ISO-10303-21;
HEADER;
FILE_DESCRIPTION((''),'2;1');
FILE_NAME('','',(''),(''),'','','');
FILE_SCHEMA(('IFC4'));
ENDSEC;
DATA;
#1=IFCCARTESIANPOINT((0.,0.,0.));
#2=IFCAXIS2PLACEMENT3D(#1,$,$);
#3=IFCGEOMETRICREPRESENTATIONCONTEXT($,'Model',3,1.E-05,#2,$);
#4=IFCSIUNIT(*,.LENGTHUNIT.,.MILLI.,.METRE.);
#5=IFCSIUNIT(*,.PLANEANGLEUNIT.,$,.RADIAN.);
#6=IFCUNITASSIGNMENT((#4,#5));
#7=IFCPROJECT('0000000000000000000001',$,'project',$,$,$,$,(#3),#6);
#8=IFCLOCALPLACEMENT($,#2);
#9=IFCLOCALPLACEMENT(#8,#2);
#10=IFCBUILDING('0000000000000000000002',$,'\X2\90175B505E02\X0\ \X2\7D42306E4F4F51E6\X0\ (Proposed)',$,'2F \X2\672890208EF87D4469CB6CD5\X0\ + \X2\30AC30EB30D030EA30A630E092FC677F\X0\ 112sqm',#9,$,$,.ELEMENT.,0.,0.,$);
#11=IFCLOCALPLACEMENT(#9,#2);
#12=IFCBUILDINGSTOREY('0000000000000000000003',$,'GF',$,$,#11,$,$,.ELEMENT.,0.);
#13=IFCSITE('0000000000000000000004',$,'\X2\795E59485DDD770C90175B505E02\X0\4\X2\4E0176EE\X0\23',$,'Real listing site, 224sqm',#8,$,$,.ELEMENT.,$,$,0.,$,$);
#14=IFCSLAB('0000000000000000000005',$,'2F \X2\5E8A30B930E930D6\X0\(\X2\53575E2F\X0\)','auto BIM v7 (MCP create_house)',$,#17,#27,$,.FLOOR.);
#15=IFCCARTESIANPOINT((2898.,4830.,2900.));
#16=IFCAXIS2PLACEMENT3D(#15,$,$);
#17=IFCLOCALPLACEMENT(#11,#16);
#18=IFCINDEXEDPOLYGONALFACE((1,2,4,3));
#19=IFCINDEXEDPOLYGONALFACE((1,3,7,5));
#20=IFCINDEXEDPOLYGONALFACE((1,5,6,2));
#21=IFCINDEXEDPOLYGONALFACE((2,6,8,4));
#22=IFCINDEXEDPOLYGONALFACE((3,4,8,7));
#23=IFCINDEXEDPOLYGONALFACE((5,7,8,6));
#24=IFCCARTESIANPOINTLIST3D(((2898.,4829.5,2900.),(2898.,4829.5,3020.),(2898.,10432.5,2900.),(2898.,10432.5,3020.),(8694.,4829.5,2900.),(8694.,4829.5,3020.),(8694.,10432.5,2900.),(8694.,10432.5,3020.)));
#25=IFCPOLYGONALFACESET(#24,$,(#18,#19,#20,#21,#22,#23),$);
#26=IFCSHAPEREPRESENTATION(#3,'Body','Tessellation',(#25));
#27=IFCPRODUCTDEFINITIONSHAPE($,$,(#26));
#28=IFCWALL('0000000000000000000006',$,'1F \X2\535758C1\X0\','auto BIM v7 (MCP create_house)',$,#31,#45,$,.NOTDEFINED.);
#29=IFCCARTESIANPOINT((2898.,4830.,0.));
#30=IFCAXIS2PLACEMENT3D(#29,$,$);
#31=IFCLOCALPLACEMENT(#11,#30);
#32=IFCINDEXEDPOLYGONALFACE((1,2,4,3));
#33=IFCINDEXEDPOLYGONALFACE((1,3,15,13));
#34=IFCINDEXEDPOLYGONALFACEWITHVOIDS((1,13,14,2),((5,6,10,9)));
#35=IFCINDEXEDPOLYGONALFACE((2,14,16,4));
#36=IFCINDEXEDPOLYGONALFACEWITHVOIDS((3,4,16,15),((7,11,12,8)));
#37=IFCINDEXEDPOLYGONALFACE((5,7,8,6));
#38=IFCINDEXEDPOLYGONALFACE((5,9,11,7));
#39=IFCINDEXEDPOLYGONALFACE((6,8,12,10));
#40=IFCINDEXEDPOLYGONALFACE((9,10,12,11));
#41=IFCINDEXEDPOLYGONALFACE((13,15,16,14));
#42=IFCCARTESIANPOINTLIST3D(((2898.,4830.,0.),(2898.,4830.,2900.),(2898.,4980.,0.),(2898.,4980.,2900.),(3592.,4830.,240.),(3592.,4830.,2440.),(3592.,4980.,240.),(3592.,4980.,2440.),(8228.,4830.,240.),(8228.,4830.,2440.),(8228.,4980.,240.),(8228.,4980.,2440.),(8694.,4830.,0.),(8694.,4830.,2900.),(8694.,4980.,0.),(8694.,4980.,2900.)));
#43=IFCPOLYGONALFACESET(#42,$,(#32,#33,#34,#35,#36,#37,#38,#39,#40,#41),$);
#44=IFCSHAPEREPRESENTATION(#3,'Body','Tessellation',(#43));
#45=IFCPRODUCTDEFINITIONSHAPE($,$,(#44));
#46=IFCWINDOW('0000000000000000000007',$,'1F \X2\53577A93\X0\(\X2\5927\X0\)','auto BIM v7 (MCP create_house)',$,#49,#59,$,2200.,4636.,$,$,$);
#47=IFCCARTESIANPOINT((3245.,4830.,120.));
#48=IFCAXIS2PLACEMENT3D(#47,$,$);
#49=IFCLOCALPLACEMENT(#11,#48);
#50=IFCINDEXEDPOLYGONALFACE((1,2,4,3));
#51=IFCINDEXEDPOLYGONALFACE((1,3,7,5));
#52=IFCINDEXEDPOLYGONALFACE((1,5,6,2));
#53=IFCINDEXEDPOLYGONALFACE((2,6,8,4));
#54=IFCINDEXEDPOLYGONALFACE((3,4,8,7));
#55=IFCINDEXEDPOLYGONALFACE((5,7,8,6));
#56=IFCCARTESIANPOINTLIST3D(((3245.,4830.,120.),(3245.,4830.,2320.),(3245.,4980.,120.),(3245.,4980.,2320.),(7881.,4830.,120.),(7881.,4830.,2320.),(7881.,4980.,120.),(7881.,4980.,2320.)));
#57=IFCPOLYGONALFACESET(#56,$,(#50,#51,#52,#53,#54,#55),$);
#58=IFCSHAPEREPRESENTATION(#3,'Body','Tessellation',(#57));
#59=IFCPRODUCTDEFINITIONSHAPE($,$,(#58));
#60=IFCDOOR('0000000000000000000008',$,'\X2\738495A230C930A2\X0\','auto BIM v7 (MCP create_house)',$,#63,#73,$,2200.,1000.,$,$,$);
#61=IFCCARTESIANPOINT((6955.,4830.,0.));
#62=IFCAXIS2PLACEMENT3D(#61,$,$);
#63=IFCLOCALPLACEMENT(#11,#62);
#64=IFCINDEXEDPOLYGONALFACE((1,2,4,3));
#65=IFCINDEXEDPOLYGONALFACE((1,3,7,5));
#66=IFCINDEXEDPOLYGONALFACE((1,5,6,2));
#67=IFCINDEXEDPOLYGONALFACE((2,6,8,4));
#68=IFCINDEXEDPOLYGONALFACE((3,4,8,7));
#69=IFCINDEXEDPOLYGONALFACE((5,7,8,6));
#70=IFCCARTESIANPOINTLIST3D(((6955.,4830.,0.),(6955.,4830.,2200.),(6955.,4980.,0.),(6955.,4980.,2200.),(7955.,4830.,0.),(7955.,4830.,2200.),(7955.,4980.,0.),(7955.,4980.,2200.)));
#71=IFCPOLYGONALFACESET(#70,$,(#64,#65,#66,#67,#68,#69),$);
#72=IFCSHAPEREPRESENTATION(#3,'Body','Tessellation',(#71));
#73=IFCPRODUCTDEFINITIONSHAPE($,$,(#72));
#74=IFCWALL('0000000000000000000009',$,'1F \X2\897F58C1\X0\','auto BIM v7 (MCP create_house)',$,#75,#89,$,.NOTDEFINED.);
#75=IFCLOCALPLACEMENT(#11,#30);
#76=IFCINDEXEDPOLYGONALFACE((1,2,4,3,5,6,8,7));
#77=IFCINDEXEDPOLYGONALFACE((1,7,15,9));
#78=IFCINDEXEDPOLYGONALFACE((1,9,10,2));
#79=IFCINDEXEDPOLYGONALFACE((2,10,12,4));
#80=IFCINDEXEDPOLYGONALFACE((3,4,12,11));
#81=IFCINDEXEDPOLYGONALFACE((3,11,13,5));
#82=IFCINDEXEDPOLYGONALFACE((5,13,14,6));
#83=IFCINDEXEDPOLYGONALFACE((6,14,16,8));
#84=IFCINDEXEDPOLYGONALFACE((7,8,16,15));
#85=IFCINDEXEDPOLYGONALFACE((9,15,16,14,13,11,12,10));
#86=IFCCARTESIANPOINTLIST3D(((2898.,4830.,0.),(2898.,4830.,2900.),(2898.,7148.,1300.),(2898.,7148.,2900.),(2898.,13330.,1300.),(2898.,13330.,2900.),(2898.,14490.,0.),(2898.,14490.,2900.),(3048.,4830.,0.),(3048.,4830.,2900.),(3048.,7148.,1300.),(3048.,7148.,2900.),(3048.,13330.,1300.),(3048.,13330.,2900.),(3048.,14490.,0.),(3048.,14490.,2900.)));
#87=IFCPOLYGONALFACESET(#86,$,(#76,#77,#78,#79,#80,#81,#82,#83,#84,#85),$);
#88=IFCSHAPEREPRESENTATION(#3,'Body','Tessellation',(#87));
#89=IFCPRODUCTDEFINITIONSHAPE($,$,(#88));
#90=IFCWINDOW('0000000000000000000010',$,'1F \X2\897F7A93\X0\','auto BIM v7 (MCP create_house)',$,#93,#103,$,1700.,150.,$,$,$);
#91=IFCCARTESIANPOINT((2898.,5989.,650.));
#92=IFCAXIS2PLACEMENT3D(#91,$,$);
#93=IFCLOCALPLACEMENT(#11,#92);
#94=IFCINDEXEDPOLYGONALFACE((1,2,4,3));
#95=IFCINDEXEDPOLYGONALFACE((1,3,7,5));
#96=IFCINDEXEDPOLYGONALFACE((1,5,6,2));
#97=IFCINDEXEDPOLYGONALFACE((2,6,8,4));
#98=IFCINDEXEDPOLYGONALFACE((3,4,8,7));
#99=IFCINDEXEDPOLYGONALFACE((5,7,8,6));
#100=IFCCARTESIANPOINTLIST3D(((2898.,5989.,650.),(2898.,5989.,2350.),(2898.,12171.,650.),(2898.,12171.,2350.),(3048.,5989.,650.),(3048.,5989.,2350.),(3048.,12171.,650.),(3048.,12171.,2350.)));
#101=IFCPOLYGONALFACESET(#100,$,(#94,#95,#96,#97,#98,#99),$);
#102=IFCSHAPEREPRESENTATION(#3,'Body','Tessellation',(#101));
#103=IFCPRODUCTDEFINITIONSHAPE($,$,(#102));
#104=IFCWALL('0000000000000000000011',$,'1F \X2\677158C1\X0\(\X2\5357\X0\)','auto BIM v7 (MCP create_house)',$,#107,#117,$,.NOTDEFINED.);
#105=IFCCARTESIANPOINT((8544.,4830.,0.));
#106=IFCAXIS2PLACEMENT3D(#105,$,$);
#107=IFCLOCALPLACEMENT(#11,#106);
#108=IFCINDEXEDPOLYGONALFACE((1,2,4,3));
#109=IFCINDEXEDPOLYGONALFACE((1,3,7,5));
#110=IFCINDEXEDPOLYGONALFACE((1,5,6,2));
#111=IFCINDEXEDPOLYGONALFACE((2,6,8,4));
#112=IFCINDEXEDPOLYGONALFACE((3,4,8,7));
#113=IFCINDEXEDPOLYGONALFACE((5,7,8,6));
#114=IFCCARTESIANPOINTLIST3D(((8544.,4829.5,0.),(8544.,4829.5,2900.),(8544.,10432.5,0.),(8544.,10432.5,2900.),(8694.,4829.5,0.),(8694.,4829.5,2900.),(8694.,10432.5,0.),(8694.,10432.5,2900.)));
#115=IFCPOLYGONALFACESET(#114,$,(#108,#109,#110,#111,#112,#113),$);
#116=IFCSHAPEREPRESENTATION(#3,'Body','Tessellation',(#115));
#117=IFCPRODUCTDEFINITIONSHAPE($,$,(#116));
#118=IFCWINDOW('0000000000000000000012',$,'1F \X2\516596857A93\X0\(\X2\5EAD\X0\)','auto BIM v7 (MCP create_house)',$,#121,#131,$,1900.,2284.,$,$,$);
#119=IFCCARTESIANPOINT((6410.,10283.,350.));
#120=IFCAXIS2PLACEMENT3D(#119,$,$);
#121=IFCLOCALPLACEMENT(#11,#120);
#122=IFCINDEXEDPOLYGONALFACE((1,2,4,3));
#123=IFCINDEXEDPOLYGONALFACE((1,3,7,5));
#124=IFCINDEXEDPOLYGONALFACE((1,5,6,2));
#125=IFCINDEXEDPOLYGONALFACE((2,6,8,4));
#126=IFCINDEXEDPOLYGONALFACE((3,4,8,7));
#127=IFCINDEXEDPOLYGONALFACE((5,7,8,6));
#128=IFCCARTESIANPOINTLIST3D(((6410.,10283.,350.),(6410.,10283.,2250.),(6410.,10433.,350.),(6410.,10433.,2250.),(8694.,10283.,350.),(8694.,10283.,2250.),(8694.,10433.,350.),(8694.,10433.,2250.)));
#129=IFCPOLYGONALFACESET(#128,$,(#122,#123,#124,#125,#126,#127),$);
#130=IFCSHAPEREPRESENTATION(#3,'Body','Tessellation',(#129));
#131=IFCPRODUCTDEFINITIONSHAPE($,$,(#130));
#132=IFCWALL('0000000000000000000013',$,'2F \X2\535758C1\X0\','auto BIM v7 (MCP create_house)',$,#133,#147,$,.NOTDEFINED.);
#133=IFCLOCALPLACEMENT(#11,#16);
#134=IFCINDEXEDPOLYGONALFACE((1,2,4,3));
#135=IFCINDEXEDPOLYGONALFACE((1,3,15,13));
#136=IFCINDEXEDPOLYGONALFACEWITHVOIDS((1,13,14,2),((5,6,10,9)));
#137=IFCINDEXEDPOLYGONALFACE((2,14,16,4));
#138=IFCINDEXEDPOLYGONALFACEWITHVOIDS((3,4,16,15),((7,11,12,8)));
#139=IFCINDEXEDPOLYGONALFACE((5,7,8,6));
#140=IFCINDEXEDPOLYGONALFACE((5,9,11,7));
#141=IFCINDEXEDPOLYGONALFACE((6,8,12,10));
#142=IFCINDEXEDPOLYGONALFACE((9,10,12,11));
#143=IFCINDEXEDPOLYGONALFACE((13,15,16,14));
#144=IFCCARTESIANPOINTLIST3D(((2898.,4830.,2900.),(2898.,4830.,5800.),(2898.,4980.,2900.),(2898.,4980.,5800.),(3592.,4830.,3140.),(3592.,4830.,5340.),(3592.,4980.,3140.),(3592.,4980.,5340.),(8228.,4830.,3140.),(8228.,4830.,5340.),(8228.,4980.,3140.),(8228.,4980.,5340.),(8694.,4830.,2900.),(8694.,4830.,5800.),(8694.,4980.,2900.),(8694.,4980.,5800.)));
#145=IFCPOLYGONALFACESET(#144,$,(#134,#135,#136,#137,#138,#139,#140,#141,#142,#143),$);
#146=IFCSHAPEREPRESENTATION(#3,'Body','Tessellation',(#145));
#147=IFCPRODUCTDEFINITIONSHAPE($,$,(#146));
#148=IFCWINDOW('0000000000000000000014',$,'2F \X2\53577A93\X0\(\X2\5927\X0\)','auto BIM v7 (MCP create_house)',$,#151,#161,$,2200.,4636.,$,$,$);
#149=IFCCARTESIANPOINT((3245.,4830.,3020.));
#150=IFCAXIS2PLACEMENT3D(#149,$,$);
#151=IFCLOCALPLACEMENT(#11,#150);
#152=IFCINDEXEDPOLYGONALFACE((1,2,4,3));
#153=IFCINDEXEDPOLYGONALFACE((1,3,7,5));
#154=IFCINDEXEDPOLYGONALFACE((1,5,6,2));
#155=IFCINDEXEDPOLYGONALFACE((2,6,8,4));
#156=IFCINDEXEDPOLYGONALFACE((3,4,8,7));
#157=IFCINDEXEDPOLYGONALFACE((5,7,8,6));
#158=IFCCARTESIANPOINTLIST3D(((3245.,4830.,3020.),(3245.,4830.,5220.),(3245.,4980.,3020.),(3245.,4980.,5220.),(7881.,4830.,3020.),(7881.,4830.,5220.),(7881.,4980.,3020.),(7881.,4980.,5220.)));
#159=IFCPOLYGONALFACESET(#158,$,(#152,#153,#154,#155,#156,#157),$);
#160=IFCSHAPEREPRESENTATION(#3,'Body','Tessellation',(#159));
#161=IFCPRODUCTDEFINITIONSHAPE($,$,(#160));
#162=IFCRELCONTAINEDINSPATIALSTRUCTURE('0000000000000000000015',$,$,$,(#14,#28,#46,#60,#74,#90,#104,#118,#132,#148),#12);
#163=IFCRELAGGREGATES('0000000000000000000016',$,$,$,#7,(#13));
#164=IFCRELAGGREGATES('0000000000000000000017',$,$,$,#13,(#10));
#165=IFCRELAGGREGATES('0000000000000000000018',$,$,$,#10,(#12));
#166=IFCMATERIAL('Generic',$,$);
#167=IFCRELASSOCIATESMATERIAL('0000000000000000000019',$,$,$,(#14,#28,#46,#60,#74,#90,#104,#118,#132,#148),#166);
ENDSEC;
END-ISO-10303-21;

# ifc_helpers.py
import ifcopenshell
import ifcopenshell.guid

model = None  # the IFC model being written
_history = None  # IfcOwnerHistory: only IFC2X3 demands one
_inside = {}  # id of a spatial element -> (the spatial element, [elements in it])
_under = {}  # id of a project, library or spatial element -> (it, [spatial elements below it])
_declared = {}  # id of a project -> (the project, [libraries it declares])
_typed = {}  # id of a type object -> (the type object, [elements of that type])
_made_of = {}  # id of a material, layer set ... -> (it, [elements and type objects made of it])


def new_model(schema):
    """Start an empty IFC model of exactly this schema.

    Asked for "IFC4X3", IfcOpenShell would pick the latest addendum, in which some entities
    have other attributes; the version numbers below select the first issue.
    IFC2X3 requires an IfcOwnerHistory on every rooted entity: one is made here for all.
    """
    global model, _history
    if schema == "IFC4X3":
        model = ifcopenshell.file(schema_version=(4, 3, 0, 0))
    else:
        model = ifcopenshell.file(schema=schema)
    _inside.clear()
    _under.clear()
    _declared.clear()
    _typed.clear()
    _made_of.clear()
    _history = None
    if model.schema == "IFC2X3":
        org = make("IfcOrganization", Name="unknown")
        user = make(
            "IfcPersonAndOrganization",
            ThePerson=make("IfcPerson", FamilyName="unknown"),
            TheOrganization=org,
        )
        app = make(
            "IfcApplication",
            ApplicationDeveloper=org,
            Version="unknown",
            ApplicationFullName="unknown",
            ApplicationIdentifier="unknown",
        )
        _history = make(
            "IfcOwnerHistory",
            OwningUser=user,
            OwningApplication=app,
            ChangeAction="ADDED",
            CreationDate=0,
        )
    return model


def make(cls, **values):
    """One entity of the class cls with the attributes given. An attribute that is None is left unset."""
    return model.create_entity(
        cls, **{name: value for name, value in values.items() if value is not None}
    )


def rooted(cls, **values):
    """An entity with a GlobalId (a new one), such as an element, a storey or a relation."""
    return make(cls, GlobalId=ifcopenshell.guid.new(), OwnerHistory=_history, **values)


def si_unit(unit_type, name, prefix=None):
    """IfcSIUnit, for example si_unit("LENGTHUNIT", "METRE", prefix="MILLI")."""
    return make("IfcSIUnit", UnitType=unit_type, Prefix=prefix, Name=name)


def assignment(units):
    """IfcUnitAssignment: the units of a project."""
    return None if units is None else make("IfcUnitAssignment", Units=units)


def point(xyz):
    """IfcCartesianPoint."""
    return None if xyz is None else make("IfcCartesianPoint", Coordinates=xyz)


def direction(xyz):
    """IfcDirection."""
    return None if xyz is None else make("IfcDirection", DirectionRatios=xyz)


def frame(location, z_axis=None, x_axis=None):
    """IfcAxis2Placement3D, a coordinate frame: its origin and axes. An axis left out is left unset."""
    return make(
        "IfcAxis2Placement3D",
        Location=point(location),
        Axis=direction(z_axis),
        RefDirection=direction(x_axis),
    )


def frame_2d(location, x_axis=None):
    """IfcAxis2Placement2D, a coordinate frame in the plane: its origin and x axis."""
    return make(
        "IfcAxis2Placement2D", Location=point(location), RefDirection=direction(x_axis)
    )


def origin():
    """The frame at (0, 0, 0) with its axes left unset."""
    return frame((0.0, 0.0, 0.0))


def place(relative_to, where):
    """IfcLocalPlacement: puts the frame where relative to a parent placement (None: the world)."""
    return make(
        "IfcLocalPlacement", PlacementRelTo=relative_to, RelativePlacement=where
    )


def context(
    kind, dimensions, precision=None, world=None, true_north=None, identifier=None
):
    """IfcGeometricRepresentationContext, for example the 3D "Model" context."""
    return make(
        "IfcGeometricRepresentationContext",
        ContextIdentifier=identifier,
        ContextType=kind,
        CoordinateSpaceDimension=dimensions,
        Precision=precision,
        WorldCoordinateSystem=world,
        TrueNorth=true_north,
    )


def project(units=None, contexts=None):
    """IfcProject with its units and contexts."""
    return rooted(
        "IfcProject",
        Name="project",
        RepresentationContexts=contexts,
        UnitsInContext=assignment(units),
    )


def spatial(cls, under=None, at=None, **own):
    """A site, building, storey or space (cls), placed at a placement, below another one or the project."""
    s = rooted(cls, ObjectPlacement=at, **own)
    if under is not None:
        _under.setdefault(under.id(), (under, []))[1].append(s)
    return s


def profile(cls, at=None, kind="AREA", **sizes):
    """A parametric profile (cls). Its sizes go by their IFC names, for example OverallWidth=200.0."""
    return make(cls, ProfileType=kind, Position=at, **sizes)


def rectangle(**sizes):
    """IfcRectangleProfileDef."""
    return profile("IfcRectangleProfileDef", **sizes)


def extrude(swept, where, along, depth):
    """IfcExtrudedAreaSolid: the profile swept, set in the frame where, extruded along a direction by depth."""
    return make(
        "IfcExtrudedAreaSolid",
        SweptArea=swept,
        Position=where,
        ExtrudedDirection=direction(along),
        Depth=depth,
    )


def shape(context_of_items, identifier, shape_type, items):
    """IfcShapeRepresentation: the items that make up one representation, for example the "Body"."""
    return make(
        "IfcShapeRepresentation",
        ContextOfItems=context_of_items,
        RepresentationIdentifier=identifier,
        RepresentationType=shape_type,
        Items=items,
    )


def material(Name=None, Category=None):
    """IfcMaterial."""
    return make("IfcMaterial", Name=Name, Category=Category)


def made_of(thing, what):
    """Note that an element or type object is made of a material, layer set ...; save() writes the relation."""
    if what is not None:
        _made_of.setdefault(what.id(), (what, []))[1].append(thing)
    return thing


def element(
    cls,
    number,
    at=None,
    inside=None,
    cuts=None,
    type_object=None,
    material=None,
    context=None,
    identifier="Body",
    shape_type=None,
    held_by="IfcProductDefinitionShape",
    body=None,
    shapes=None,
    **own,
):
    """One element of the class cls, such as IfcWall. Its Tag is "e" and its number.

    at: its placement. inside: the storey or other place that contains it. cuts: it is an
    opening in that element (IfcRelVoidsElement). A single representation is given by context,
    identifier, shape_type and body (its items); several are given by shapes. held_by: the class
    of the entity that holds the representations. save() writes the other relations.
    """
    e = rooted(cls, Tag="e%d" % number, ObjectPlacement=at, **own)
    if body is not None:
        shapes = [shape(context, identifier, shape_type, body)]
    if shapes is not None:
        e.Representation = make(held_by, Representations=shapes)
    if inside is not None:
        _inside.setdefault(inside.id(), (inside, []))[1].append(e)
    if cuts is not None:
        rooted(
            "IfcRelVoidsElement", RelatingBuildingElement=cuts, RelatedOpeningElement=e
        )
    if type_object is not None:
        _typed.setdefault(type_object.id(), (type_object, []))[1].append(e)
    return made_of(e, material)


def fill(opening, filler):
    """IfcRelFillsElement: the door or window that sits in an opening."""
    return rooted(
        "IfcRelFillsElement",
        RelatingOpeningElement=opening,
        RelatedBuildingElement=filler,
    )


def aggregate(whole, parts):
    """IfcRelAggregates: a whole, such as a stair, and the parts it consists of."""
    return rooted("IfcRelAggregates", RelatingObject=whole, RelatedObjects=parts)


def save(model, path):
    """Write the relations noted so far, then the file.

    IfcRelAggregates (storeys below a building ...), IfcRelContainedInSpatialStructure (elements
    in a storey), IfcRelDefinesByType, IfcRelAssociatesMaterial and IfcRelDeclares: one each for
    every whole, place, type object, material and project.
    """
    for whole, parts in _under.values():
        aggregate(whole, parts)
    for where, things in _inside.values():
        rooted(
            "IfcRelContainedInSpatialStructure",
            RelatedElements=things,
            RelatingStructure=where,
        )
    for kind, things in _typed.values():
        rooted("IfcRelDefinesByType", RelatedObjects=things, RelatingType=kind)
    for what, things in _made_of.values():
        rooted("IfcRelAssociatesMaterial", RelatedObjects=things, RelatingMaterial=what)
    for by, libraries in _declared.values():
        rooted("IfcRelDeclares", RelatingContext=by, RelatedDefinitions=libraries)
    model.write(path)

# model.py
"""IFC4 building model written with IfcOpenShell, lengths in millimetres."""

from ifc_helpers import new_model, si_unit, frame, frame_2d, origin, place, context, project, spatial, rectangle, extrude, material, element, fill, save


model = new_model("IFC4")

# Units and contexts
model_context = context("Model", 3, precision=1e-05, world=origin())
ifc_project = project(units=[si_unit("LENGTHUNIT", "METRE", prefix="MILLI"), si_unit("PLANEANGLEUNIT", "RADIAN")], contexts=[model_context])

# Site, building, storey
site_placement = place(None, origin())
site = spatial("IfcSite", under=ifc_project, at=site_placement, Name="神奈川県逗子市4丁目23", ObjectType="Real listing site, 224sqm", CompositionType="ELEMENT", RefElevation=0.0)
building_placement = place(site_placement, origin())
building = spatial("IfcBuilding", under=site, at=building_placement, Name="逗子市 終の住処 (Proposed)", ObjectType="2F 木造軸組構法 + ガルバリウム鋼板 112sqm", CompositionType="ELEMENT", ElevationOfRefHeight=0.0, ElevationOfTerrain=0.0)
storey_placement = place(building_placement, origin())
storey = spatial("IfcBuildingStorey", under=building, at=storey_placement, Name="GF", CompositionType="ELEMENT", Elevation=0.0)

# Slab
ifc_material = material(Name="Generic")
slab_1_placement = place(storey_placement, frame((2898.0, 4830.0, 2900.0)))
element("IfcSlab", 1, at=slab_1_placement, inside=storey, material=ifc_material, Name="2F 床スラブ(南帯)", Description="auto BIM v7 (MCP create_house)", PredefinedType="FLOOR", context=model_context, shape_type="SweptSolid", body=[
    extrude(rectangle(XDim=5796.0, YDim=5603.0, at=frame_2d((2898.0, 2801.0))), frame((2898.0, 4830.0, 2900.0)), (0.0, 0.0, 1.0), 120.0),
])

# Wall, openings, window, door
wall_1_placement = place(storey_placement, frame((2898.0, 4830.0, 0.0)))
wall_1 = element("IfcWall", 2, at=wall_1_placement, inside=storey, material=ifc_material, Name="1F 南壁", Description="auto BIM v7 (MCP create_house)", PredefinedType="NOTDEFINED", context=model_context, shape_type="SweptSolid", body=[
    extrude(rectangle(XDim=5796.0, YDim=150.0, at=frame_2d((2898.0, 75.0))), frame((2898.0, 4830.0, 0.0)), (0.0, 0.0, 1.0), 2900.0),
])
opening_1_placement = place(storey_placement, frame((3245.0, 4830.0, 120.0)))
opening_1 = element("IfcOpeningElement", 3, at=opening_1_placement, cuts=wall_1, PredefinedType="NOTDEFINED", context=model_context, shape_type="SweptSolid", body=[
    extrude(rectangle(XDim=4636.0, YDim=150.0, at=frame_2d((2318.0, 75.0))), frame((3245.0, 4830.0, 120.0)), (0.0, 0.0, 1.0), 2200.0),
])
opening_2_placement = place(storey_placement, frame((6955.0, 4830.0, 0.0)))
opening_2 = element("IfcOpeningElement", 4, at=opening_2_placement, cuts=wall_1, PredefinedType="NOTDEFINED", context=model_context, shape_type="SweptSolid", body=[
    extrude(rectangle(XDim=1000.0, YDim=150.0, at=frame_2d((500.0, 75.0))), frame((6955.0, 4830.0, 0.0)), (0.0, 0.0, 1.0), 2200.0),
])
window_1_placement = place(storey_placement, frame((3245.0, 4830.0, 120.0)))
window_1 = element("IfcWindow", 5, at=window_1_placement, inside=storey, material=ifc_material, Name="1F 南窓(大)", Description="auto BIM v7 (MCP create_house)", OverallHeight=2200.0, OverallWidth=4636.0, context=model_context, shape_type="SweptSolid", body=[
    extrude(rectangle(XDim=4636.0, YDim=150.0, at=frame_2d((2318.0, 75.0))), frame((3245.0, 4830.0, 120.0)), (0.0, 0.0, 1.0), 2200.0),
])
fill(opening_1, window_1)
door_placement = place(storey_placement, frame((6955.0, 4830.0, 0.0)))
door = element("IfcDoor", 6, at=door_placement, inside=storey, material=ifc_material, Name="玄関ドア", Description="auto BIM v7 (MCP create_house)", OverallHeight=2200.0, OverallWidth=1000.0, context=model_context, shape_type="SweptSolid", body=[
    extrude(rectangle(XDim=1000.0, YDim=150.0, at=frame_2d((500.0, 75.0))), frame((6955.0, 4830.0, 0.0)), (0.0, 0.0, 1.0), 2200.0),
])
fill(opening_2, door)

# Walls, openings, windows
wall_2_placement = place(storey_placement, frame((2898.0, 4830.0, 0.0)))
wall_2 = element("IfcWall", 7, at=wall_2_placement, inside=storey, material=ifc_material, Name="1F 西壁", Description="auto BIM v7 (MCP create_house)", PredefinedType="NOTDEFINED", context=model_context, shape_type="SweptSolid", body=[
    extrude(rectangle(XDim=150.0, YDim=9660.0, at=frame_2d((75.0, 4830.0))), frame((2898.0, 4830.0, 0.0)), (0.0, 0.0, 1.0), 2900.0),
])
opening_3_placement = place(storey_placement, frame((2898.0, 5989.0, 650.0)))
opening_3 = element("IfcOpeningElement", 8, at=opening_3_placement, cuts=wall_2, PredefinedType="NOTDEFINED", context=model_context, shape_type="SweptSolid", body=[
    extrude(rectangle(XDim=150.0, YDim=6182.0, at=frame_2d((75.0, 3091.0))), frame((2898.0, 5989.0, 650.0)), (0.0, 0.0, 1.0), 1700.0),
])
window_2_placement = place(storey_placement, frame((2898.0, 5989.0, 650.0)))
window_2 = element("IfcWindow", 9, at=window_2_placement, inside=storey, material=ifc_material, Name="1F 西窓", Description="auto BIM v7 (MCP create_house)", OverallHeight=1700.0, OverallWidth=150.0, context=model_context, shape_type="SweptSolid", body=[
    extrude(rectangle(XDim=150.0, YDim=6182.0, at=frame_2d((75.0, 3091.0))), frame((2898.0, 5989.0, 650.0)), (0.0, 0.0, 1.0), 1700.0),
])
fill(opening_3, window_2)
wall_3_placement = place(storey_placement, frame((8544.0, 4830.0, 0.0)))
wall_3 = element("IfcWall", 10, at=wall_3_placement, inside=storey, material=ifc_material, Name="1F 東壁(南)", Description="auto BIM v7 (MCP create_house)", PredefinedType="NOTDEFINED", context=model_context, shape_type="SweptSolid", body=[
    extrude(rectangle(XDim=150.0, YDim=5603.0, at=frame_2d((75.0, 2801.0))), frame((8544.0, 4830.0, 0.0)), (0.0, 0.0, 1.0), 2900.0),
])
opening_4_placement = place(storey_placement, frame((6410.0, 10283.0, 350.0)))
opening_4 = element("IfcOpeningElement", 11, at=opening_4_placement, cuts=wall_3, PredefinedType="NOTDEFINED", context=model_context, shape_type="SweptSolid", body=[
    extrude(rectangle(XDim=2284.0, YDim=150.0, at=frame_2d((1142.0, 75.0))), frame((6410.0, 10283.0, 350.0)), (0.0, 0.0, 1.0), 1900.0),
])
window_3_placement = place(storey_placement, frame((6410.0, 10283.0, 350.0)))
window_3 = element("IfcWindow", 12, at=window_3_placement, inside=storey, material=ifc_material, Name="1F 入隅窓(庭)", Description="auto BIM v7 (MCP create_house)", OverallHeight=1900.0, OverallWidth=2284.0, context=model_context, shape_type="SweptSolid", body=[
    extrude(rectangle(XDim=2284.0, YDim=150.0, at=frame_2d((1142.0, 75.0))), frame((6410.0, 10283.0, 350.0)), (0.0, 0.0, 1.0), 1900.0),
])
fill(opening_4, window_3)

# Wall, opening, window
wall_4_placement = place(storey_placement, frame((2898.0, 4830.0, 2900.0)))
wall_4 = element("IfcWall", 13, at=wall_4_placement, inside=storey, material=ifc_material, Name="2F 南壁", Description="auto BIM v7 (MCP create_house)", PredefinedType="NOTDEFINED", context=model_context, shape_type="SweptSolid", body=[
    extrude(rectangle(XDim=5796.0, YDim=150.0, at=frame_2d((2898.0, 75.0))), frame((2898.0, 4830.0, 2900.0)), (0.0, 0.0, 1.0), 2900.0),
])
opening_5_placement = place(storey_placement, frame((3245.0, 4830.0, 3020.0)))
opening_5 = element("IfcOpeningElement", 14, at=opening_5_placement, cuts=wall_4, PredefinedType="NOTDEFINED", context=model_context, shape_type="SweptSolid", body=[
    extrude(rectangle(XDim=4636.0, YDim=150.0, at=frame_2d((2318.0, 75.0))), frame((3245.0, 4830.0, 3020.0)), (0.0, 0.0, 1.0), 2200.0),
])
window_4_placement = place(storey_placement, frame((3245.0, 4830.0, 3020.0)))
window_4 = element("IfcWindow", 15, at=window_4_placement, inside=storey, material=ifc_material, Name="2F 南窓(大)", Description="auto BIM v7 (MCP create_house)", OverallHeight=2200.0, OverallWidth=4636.0, context=model_context, shape_type="SweptSolid", body=[
    extrude(rectangle(XDim=4636.0, YDim=150.0, at=frame_2d((2318.0, 75.0))), frame((3245.0, 4830.0, 3020.0)), (0.0, 0.0, 1.0), 2200.0),
])
fill(opening_5, window_4)

save(model, "model.ifc")
